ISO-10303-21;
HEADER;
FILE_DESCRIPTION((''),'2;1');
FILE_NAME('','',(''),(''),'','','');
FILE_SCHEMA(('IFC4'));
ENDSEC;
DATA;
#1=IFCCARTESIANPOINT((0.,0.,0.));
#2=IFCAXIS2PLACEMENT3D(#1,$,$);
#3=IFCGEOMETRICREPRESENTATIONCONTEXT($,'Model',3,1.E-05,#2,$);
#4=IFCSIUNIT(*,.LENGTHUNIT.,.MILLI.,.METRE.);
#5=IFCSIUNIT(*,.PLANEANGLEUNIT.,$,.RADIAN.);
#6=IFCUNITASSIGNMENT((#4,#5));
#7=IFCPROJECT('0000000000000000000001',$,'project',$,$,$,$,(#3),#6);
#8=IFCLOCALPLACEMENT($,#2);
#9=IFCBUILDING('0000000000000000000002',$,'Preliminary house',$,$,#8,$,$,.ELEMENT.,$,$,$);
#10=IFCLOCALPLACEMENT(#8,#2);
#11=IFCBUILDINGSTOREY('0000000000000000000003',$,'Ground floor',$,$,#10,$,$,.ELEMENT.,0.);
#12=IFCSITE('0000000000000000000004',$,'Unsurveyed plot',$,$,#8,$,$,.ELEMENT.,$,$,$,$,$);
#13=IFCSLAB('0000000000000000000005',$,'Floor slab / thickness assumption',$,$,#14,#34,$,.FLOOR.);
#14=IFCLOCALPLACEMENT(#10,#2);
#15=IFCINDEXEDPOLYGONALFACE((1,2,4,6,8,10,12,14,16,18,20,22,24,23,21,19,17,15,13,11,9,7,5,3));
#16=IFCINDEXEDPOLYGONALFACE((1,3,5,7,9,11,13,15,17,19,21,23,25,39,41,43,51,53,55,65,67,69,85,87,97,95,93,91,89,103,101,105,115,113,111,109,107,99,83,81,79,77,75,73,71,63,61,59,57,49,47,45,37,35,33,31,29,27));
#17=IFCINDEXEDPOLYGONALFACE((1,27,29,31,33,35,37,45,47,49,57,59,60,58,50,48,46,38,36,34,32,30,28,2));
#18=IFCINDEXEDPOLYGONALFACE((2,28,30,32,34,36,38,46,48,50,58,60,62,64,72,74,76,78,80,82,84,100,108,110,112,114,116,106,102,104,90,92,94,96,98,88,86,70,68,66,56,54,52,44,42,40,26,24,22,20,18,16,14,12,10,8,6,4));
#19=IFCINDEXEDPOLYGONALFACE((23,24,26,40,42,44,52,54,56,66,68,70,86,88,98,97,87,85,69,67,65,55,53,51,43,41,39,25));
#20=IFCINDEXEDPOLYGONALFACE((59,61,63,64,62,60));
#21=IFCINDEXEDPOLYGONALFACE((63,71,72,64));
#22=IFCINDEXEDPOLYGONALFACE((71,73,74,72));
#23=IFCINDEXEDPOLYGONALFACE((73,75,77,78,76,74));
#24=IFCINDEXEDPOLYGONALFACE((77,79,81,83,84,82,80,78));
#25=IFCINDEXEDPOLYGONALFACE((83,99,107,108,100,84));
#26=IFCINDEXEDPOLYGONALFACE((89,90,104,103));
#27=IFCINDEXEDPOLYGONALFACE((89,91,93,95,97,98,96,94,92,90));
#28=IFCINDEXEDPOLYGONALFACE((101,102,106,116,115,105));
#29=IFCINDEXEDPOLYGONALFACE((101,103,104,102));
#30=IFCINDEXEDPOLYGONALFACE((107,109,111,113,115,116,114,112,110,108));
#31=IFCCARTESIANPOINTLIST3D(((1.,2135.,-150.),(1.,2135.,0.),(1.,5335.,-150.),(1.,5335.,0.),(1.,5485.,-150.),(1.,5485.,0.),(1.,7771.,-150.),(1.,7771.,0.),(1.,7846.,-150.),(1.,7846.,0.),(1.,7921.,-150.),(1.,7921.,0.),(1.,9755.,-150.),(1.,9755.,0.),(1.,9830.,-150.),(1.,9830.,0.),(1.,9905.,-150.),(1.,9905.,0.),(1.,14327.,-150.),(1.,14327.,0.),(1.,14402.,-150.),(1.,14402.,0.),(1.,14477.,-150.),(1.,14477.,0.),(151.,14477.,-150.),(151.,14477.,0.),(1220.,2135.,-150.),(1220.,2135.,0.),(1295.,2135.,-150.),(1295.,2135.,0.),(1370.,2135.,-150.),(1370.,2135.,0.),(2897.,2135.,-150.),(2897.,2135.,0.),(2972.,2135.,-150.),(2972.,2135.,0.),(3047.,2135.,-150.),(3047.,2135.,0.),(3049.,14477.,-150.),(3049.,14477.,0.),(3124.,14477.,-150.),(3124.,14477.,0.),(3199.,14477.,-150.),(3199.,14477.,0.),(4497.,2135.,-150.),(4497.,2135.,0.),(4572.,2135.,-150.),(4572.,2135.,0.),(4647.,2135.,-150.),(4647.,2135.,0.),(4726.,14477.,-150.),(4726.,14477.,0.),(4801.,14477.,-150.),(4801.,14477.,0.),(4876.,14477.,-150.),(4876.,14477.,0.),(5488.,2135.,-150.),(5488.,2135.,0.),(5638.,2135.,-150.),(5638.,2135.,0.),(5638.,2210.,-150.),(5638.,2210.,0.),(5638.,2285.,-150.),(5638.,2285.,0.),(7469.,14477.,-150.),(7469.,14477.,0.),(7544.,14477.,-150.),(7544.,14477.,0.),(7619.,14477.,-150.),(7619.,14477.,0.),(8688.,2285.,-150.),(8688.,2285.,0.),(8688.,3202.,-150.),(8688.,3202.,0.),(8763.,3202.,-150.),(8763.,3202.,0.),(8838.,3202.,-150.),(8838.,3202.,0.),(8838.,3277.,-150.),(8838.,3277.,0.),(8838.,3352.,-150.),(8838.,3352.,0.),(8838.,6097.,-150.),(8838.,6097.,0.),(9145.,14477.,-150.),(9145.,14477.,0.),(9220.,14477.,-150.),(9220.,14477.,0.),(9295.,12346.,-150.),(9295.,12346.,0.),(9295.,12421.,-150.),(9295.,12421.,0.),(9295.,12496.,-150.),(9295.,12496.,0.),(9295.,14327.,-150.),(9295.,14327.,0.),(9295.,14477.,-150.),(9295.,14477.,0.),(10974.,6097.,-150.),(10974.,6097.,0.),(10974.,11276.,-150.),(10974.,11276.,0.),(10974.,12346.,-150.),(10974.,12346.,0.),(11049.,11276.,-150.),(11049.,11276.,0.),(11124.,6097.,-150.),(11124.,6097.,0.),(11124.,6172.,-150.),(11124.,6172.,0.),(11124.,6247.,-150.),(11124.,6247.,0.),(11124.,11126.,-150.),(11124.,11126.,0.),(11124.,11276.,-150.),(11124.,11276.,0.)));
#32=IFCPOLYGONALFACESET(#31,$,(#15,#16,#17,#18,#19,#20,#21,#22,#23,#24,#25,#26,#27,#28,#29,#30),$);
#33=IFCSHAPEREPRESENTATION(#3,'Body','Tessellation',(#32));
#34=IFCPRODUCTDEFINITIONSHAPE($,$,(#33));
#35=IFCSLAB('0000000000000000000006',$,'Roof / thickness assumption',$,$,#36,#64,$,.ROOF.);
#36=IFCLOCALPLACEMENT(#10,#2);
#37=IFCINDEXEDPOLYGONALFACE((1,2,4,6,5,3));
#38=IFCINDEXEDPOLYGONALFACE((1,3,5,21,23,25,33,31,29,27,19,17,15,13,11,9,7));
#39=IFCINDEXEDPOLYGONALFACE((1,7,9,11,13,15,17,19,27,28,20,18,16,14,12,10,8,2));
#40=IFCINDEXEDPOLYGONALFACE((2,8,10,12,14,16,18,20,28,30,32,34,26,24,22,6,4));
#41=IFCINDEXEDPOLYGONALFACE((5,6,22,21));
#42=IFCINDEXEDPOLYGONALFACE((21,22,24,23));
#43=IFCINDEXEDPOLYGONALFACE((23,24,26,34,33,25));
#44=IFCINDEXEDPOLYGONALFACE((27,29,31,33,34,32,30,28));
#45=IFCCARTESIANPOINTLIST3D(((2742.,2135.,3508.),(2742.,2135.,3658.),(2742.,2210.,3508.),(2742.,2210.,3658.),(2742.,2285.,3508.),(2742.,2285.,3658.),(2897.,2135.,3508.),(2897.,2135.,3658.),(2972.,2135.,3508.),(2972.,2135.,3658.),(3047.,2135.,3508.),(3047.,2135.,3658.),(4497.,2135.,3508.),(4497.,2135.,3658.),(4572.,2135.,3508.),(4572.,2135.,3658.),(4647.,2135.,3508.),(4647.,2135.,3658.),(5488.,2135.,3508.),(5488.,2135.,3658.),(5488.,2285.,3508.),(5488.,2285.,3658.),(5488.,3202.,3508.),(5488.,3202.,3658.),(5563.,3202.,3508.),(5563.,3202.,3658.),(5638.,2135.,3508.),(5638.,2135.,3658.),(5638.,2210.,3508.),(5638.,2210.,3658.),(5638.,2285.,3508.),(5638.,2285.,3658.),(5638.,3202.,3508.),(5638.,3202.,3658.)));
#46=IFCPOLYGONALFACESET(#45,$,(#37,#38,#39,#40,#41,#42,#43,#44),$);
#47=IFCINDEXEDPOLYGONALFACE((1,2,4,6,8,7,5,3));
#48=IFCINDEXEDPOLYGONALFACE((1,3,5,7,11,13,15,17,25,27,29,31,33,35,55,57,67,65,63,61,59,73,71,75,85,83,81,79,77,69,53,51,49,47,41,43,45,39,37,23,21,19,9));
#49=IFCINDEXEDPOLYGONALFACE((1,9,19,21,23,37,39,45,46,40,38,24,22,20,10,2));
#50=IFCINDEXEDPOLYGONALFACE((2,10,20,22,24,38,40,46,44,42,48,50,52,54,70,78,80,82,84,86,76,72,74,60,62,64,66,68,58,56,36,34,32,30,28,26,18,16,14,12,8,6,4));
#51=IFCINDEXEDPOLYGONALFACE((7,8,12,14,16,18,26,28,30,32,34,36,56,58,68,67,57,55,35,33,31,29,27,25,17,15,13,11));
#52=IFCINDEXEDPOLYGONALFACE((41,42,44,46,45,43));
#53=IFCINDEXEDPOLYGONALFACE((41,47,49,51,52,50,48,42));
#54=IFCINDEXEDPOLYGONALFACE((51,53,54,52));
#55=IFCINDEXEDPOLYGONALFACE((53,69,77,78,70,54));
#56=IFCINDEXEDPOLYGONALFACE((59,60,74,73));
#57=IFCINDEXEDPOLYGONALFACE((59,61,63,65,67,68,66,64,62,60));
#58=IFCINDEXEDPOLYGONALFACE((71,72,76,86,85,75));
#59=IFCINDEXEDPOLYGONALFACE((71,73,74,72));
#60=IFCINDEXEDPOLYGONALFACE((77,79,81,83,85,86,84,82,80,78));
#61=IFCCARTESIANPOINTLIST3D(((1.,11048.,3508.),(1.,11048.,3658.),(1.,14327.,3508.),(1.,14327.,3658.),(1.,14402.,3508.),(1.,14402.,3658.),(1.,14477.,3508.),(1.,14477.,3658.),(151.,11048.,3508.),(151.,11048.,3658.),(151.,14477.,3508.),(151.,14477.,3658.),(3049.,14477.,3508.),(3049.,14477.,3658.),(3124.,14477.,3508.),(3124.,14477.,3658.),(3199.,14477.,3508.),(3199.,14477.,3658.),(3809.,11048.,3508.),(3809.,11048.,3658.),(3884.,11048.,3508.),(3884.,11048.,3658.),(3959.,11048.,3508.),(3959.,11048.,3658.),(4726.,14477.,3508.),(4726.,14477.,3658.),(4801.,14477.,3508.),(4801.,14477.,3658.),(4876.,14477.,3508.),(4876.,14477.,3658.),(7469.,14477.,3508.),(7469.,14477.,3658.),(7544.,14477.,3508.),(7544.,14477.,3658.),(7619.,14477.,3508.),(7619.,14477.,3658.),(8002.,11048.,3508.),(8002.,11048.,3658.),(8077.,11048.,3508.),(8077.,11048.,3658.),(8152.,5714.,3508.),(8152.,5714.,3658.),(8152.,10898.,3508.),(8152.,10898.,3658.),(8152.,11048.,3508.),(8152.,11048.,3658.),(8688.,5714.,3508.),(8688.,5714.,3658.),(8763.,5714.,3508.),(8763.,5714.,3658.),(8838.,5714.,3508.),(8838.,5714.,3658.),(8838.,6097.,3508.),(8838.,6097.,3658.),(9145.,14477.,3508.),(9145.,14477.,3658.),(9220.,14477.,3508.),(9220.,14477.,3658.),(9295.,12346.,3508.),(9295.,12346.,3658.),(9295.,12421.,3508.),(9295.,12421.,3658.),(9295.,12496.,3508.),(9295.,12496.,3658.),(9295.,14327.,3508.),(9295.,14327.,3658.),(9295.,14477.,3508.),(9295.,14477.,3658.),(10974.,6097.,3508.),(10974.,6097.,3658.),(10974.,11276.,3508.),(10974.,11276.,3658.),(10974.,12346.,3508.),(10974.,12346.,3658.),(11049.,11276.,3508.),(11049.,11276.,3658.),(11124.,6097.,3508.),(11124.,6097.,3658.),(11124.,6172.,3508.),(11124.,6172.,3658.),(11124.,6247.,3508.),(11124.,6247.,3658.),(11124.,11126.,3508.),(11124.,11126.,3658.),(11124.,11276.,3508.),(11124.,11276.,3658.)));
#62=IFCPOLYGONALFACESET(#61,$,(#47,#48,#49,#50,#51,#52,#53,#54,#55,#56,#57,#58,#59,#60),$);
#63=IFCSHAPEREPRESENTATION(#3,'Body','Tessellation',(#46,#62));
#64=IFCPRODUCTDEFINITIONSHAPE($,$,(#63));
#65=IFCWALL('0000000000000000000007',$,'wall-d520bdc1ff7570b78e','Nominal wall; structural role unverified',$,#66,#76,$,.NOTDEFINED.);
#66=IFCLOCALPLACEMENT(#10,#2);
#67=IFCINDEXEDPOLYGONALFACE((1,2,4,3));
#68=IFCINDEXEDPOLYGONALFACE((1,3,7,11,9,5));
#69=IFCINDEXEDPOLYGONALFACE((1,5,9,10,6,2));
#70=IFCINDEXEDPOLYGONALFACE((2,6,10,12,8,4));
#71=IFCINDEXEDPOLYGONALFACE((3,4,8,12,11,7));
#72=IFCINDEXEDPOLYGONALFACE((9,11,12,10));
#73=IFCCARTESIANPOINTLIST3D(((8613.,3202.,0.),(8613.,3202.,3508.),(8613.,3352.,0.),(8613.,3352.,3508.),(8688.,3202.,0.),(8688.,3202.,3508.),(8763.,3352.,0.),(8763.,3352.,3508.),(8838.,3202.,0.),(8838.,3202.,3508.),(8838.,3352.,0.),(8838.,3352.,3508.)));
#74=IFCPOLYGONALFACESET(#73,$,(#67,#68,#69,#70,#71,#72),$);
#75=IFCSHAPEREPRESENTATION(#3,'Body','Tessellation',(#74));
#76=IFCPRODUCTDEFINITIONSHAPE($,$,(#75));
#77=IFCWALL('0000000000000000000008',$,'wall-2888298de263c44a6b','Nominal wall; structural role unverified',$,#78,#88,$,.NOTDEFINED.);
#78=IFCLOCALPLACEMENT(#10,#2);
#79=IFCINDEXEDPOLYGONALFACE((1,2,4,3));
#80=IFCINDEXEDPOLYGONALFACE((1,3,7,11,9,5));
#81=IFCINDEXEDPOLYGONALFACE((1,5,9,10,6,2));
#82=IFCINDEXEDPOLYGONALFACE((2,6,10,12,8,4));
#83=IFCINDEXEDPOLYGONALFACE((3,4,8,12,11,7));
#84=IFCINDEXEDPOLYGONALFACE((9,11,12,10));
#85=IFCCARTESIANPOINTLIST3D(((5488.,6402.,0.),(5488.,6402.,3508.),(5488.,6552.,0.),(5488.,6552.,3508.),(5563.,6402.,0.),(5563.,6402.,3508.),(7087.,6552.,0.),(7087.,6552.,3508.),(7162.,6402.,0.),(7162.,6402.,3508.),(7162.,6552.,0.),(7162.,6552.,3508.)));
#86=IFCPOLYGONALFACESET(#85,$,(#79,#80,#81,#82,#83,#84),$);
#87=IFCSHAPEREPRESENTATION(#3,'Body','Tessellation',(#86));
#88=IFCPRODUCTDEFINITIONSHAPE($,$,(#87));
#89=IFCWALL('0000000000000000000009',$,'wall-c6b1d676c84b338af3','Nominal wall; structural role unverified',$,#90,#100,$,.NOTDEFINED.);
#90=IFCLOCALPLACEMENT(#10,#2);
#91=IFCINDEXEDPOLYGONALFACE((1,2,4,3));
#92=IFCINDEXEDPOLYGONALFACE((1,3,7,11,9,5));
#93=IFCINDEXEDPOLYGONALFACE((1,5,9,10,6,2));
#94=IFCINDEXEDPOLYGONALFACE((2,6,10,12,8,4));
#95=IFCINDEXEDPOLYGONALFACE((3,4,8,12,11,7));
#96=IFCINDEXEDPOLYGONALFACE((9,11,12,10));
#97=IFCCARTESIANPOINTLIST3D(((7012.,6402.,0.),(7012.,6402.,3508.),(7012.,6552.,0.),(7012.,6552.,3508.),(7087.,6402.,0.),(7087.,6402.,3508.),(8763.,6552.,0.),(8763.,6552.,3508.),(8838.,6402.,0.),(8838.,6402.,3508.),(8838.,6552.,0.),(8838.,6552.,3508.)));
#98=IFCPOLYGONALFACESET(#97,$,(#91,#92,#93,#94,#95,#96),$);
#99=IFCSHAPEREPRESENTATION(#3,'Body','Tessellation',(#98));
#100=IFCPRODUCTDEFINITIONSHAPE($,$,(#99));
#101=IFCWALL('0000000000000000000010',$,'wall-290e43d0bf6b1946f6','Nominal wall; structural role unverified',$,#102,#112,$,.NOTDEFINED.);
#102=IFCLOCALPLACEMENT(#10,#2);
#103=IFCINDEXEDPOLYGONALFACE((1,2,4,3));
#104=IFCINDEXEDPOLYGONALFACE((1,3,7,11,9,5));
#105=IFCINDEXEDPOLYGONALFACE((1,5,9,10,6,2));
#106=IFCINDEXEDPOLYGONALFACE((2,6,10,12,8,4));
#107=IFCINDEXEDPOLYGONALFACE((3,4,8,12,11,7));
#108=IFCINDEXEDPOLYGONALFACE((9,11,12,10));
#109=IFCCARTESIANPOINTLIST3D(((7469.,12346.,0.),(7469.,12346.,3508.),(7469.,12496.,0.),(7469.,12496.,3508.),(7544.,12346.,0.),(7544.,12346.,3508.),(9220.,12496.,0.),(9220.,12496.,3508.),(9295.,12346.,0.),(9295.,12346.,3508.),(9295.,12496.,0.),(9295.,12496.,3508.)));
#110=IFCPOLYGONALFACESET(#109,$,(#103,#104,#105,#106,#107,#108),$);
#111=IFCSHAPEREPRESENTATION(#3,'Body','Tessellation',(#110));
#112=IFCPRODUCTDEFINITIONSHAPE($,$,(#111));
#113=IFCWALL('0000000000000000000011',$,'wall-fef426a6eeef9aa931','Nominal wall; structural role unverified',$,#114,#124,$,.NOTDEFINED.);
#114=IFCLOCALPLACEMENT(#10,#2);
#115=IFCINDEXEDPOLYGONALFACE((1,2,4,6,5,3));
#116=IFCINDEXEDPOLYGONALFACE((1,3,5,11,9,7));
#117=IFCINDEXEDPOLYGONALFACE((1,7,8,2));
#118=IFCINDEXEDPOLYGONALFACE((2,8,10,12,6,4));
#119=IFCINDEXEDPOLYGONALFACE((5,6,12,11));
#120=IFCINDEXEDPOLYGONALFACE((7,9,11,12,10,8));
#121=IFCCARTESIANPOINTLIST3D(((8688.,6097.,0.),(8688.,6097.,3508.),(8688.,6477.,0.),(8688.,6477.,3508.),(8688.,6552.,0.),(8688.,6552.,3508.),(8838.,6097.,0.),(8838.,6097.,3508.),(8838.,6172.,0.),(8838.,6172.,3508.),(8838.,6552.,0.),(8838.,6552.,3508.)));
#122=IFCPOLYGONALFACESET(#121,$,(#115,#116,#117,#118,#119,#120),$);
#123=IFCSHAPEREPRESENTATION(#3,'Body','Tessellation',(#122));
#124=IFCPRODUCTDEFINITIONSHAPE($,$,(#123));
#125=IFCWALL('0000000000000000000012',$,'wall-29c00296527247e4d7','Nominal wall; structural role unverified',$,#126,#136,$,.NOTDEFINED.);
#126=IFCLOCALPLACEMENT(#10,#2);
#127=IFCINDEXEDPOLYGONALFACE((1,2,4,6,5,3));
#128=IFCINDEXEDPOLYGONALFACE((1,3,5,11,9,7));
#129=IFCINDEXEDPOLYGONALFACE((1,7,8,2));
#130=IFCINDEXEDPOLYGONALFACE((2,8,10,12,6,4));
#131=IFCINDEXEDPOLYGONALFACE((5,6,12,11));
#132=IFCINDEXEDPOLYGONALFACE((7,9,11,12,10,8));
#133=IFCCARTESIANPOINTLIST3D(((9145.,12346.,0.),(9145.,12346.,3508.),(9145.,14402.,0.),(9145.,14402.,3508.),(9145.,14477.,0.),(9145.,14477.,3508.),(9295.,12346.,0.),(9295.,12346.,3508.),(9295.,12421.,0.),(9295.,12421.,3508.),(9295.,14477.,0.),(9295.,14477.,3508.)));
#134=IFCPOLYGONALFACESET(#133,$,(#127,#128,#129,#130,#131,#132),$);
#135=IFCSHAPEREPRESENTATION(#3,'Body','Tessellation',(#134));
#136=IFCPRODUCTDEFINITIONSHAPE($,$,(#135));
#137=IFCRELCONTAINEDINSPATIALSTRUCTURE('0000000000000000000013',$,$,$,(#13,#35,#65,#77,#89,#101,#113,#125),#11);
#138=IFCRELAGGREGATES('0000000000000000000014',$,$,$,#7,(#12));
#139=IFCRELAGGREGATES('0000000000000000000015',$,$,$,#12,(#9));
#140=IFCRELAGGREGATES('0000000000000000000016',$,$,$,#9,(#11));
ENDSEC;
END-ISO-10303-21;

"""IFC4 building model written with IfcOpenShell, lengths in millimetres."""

from ifc_helpers import new_model, si_unit, frame, origin, place, context, project, spatial, polyline, outline, extrude, element, save


model = new_model("IFC4")

# Units and contexts
model_context = context("Model", 3, precision=1e-05, world=origin())
ifc_project = project(units=[si_unit("LENGTHUNIT", "METRE", prefix="MILLI"), si_unit("PLANEANGLEUNIT", "RADIAN")], contexts=[model_context])

# Site, building, storey
placement_1 = place(None, origin())
site = spatial("IfcSite", under=ifc_project, at=placement_1, Name="Unsurveyed plot", CompositionType="ELEMENT")
building = spatial("IfcBuilding", under=site, at=placement_1, Name="Preliminary house", CompositionType="ELEMENT")
placement_2 = place(placement_1, origin())
storey = spatial("IfcBuildingStorey", under=building, at=placement_2, Name="Ground floor", CompositionType="ELEMENT", Elevation=0.0)

# Slabs
element("IfcSlab", 1, at=placement_2, inside=storey, Name="Floor slab / thickness assumption", PredefinedType="FLOOR", context=model_context, shape_type="SweptSolid", body=[
    extrude(outline(polyline([(1220.0, 2135.0), (1.0, 2135.0), (1.0, 5335.0), (1.0, 5485.0), (1.0, 7771.0), (1.0, 7846.0), (1.0, 7921.0), (1.0, 9755.0), (1.0, 9830.0), (1.0, 9905.0), (1.0, 14327.0), (1.0, 14402.0), (1.0, 14477.0), (151.0, 14477.0), (3049.0, 14477.0), (3124.0, 14477.0), (3199.0, 14477.0), (4726.0, 14477.0), (4801.0, 14477.0), (4876.0, 14477.0), (7469.0, 14477.0), (7544.0, 14477.0), (7619.0, 14477.0), (9145.0, 14477.0), (9220.0, 14477.0), (9295.0, 14477.0), (9295.0, 14327.0), (9295.0, 12496.0), (9295.0, 12421.0), (9295.0, 12346.0), (10974.0, 12346.0), (10974.0, 11276.0), (11049.0, 11276.0), (11124.0, 11276.0), (11124.0, 11126.0), (11124.0, 6247.0), (11124.0, 6172.0), (11124.0, 6097.0), (10974.0, 6097.0), (8838.0, 6097.0), (8838.0, 3352.0), (8838.0, 3277.0), (8838.0, 3202.0), (8763.0, 3202.0), (8688.0, 3202.0), (8688.0, 2285.0), (5638.0, 2285.0), (5638.0, 2210.0), (5638.0, 2135.0), (5488.0, 2135.0), (4647.0, 2135.0), (4572.0, 2135.0), (4497.0, 2135.0), (3047.0, 2135.0), (2972.0, 2135.0), (2897.0, 2135.0), (1370.0, 2135.0), (1295.0, 2135.0), (1220.0, 2135.0)])), frame((0.0, 0.0, -150.0)), (0.0, 0.0, 1.0), 150.0),
])
element("IfcSlab", 2, at=placement_2, inside=storey, Name="Roof / thickness assumption", PredefinedType="ROOF", context=model_context, shape_type="SweptSolid", body=[
    extrude(outline(polyline([(5638.0, 2210.0), (5638.0, 2135.0), (5488.0, 2135.0), (4647.0, 2135.0), (4572.0, 2135.0), (4497.0, 2135.0), (3047.0, 2135.0), (2972.0, 2135.0), (2897.0, 2135.0), (2742.0, 2135.0), (2742.0, 2210.0), (2742.0, 2285.0), (5488.0, 2285.0), (5488.0, 3202.0), (5563.0, 3202.0), (5638.0, 3202.0), (5638.0, 2285.0), (5638.0, 2210.0)])), frame((0.0, 0.0, 3508.0)), (0.0, 0.0, 1.0), 150.0),
    extrude(outline(polyline([(1.0, 14402.0), (1.0, 14477.0), (151.0, 14477.0), (3049.0, 14477.0), (3124.0, 14477.0), (3199.0, 14477.0), (4726.0, 14477.0), (4801.0, 14477.0), (4876.0, 14477.0), (7469.0, 14477.0), (7544.0, 14477.0), (7619.0, 14477.0), (9145.0, 14477.0), (9220.0, 14477.0), (9295.0, 14477.0), (9295.0, 14327.0), (9295.0, 12496.0), (9295.0, 12421.0), (9295.0, 12346.0), (10974.0, 12346.0), (10974.0, 11276.0), (11049.0, 11276.0), (11124.0, 11276.0), (11124.0, 11126.0), (11124.0, 6247.0), (11124.0, 6172.0), (11124.0, 6097.0), (10974.0, 6097.0), (8838.0, 6097.0), (8838.0, 5714.0), (8763.0, 5714.0), (8688.0, 5714.0), (8152.0, 5714.0), (8152.0, 10898.0), (8152.0, 11048.0), (8077.0, 11048.0), (8002.0, 11048.0), (3959.0, 11048.0), (3884.0, 11048.0), (3809.0, 11048.0), (151.0, 11048.0), (1.0, 11048.0), (1.0, 14327.0), (1.0, 14402.0)])), frame((0.0, 0.0, 3508.0)), (0.0, 0.0, 1.0), 150.0),
])

# Walls
element("IfcWall", 3, at=placement_2, inside=storey, Name="wall-d520bdc1ff7570b78e", Description="Nominal wall; structural role unverified", PredefinedType="NOTDEFINED", context=model_context, shape_type="SweptSolid", body=[
    extrude(outline(polyline([(8763.0, 3352.0), (8838.0, 3352.0), (8838.0, 3202.0), (8688.0, 3202.0), (8613.0, 3202.0), (8613.0, 3352.0), (8763.0, 3352.0)])), origin(), (0.0, 0.0, 1.0), 3508.0),
])
element("IfcWall", 4, at=placement_2, inside=storey, Name="wall-2888298de263c44a6b", Description="Nominal wall; structural role unverified", PredefinedType="NOTDEFINED", context=model_context, shape_type="SweptSolid", body=[
    extrude(outline(polyline([(7087.0, 6552.0), (7162.0, 6552.0), (7162.0, 6402.0), (5563.0, 6402.0), (5488.0, 6402.0), (5488.0, 6552.0), (7087.0, 6552.0)])), origin(), (0.0, 0.0, 1.0), 3508.0),
])

# Wall
element("IfcWall", 5, at=placement_2, inside=storey, Name="wall-c6b1d676c84b338af3", Description="Nominal wall; structural role unverified", PredefinedType="NOTDEFINED", context=model_context, shape_type="SweptSolid", body=[
    extrude(outline(polyline([(8763.0, 6552.0), (8838.0, 6552.0), (8838.0, 6402.0), (7087.0, 6402.0), (7012.0, 6402.0), (7012.0, 6552.0), (8763.0, 6552.0)])), origin(), (0.0, 0.0, 1.0), 3508.0),
])

# Wall
element("IfcWall", 6, at=placement_2, inside=storey, Name="wall-290e43d0bf6b1946f6", Description="Nominal wall; structural role unverified", PredefinedType="NOTDEFINED", context=model_context, shape_type="SweptSolid", body=[
    extrude(outline(polyline([(9220.0, 12496.0), (9295.0, 12496.0), (9295.0, 12346.0), (7544.0, 12346.0), (7469.0, 12346.0), (7469.0, 12496.0), (9220.0, 12496.0)])), origin(), (0.0, 0.0, 1.0), 3508.0),
])

# Wall
element("IfcWall", 7, at=placement_2, inside=storey, Name="wall-fef426a6eeef9aa931", Description="Nominal wall; structural role unverified", PredefinedType="NOTDEFINED", context=model_context, shape_type="SweptSolid", body=[
    extrude(outline(polyline([(8688.0, 6477.0), (8688.0, 6552.0), (8838.0, 6552.0), (8838.0, 6172.0), (8838.0, 6097.0), (8688.0, 6097.0), (8688.0, 6477.0)])), origin(), (0.0, 0.0, 1.0), 3508.0),
])

# Wall
element("IfcWall", 8, at=placement_2, inside=storey, Name="wall-29c00296527247e4d7", Description="Nominal wall; structural role unverified", PredefinedType="NOTDEFINED", context=model_context, shape_type="SweptSolid", body=[
    extrude(outline(polyline([(9145.0, 14402.0), (9145.0, 14477.0), (9295.0, 14477.0), (9295.0, 12421.0), (9295.0, 12346.0), (9145.0, 12346.0), (9145.0, 14402.0)])), origin(), (0.0, 0.0, 1.0), 3508.0),
])

save(model, "model.ifc")
